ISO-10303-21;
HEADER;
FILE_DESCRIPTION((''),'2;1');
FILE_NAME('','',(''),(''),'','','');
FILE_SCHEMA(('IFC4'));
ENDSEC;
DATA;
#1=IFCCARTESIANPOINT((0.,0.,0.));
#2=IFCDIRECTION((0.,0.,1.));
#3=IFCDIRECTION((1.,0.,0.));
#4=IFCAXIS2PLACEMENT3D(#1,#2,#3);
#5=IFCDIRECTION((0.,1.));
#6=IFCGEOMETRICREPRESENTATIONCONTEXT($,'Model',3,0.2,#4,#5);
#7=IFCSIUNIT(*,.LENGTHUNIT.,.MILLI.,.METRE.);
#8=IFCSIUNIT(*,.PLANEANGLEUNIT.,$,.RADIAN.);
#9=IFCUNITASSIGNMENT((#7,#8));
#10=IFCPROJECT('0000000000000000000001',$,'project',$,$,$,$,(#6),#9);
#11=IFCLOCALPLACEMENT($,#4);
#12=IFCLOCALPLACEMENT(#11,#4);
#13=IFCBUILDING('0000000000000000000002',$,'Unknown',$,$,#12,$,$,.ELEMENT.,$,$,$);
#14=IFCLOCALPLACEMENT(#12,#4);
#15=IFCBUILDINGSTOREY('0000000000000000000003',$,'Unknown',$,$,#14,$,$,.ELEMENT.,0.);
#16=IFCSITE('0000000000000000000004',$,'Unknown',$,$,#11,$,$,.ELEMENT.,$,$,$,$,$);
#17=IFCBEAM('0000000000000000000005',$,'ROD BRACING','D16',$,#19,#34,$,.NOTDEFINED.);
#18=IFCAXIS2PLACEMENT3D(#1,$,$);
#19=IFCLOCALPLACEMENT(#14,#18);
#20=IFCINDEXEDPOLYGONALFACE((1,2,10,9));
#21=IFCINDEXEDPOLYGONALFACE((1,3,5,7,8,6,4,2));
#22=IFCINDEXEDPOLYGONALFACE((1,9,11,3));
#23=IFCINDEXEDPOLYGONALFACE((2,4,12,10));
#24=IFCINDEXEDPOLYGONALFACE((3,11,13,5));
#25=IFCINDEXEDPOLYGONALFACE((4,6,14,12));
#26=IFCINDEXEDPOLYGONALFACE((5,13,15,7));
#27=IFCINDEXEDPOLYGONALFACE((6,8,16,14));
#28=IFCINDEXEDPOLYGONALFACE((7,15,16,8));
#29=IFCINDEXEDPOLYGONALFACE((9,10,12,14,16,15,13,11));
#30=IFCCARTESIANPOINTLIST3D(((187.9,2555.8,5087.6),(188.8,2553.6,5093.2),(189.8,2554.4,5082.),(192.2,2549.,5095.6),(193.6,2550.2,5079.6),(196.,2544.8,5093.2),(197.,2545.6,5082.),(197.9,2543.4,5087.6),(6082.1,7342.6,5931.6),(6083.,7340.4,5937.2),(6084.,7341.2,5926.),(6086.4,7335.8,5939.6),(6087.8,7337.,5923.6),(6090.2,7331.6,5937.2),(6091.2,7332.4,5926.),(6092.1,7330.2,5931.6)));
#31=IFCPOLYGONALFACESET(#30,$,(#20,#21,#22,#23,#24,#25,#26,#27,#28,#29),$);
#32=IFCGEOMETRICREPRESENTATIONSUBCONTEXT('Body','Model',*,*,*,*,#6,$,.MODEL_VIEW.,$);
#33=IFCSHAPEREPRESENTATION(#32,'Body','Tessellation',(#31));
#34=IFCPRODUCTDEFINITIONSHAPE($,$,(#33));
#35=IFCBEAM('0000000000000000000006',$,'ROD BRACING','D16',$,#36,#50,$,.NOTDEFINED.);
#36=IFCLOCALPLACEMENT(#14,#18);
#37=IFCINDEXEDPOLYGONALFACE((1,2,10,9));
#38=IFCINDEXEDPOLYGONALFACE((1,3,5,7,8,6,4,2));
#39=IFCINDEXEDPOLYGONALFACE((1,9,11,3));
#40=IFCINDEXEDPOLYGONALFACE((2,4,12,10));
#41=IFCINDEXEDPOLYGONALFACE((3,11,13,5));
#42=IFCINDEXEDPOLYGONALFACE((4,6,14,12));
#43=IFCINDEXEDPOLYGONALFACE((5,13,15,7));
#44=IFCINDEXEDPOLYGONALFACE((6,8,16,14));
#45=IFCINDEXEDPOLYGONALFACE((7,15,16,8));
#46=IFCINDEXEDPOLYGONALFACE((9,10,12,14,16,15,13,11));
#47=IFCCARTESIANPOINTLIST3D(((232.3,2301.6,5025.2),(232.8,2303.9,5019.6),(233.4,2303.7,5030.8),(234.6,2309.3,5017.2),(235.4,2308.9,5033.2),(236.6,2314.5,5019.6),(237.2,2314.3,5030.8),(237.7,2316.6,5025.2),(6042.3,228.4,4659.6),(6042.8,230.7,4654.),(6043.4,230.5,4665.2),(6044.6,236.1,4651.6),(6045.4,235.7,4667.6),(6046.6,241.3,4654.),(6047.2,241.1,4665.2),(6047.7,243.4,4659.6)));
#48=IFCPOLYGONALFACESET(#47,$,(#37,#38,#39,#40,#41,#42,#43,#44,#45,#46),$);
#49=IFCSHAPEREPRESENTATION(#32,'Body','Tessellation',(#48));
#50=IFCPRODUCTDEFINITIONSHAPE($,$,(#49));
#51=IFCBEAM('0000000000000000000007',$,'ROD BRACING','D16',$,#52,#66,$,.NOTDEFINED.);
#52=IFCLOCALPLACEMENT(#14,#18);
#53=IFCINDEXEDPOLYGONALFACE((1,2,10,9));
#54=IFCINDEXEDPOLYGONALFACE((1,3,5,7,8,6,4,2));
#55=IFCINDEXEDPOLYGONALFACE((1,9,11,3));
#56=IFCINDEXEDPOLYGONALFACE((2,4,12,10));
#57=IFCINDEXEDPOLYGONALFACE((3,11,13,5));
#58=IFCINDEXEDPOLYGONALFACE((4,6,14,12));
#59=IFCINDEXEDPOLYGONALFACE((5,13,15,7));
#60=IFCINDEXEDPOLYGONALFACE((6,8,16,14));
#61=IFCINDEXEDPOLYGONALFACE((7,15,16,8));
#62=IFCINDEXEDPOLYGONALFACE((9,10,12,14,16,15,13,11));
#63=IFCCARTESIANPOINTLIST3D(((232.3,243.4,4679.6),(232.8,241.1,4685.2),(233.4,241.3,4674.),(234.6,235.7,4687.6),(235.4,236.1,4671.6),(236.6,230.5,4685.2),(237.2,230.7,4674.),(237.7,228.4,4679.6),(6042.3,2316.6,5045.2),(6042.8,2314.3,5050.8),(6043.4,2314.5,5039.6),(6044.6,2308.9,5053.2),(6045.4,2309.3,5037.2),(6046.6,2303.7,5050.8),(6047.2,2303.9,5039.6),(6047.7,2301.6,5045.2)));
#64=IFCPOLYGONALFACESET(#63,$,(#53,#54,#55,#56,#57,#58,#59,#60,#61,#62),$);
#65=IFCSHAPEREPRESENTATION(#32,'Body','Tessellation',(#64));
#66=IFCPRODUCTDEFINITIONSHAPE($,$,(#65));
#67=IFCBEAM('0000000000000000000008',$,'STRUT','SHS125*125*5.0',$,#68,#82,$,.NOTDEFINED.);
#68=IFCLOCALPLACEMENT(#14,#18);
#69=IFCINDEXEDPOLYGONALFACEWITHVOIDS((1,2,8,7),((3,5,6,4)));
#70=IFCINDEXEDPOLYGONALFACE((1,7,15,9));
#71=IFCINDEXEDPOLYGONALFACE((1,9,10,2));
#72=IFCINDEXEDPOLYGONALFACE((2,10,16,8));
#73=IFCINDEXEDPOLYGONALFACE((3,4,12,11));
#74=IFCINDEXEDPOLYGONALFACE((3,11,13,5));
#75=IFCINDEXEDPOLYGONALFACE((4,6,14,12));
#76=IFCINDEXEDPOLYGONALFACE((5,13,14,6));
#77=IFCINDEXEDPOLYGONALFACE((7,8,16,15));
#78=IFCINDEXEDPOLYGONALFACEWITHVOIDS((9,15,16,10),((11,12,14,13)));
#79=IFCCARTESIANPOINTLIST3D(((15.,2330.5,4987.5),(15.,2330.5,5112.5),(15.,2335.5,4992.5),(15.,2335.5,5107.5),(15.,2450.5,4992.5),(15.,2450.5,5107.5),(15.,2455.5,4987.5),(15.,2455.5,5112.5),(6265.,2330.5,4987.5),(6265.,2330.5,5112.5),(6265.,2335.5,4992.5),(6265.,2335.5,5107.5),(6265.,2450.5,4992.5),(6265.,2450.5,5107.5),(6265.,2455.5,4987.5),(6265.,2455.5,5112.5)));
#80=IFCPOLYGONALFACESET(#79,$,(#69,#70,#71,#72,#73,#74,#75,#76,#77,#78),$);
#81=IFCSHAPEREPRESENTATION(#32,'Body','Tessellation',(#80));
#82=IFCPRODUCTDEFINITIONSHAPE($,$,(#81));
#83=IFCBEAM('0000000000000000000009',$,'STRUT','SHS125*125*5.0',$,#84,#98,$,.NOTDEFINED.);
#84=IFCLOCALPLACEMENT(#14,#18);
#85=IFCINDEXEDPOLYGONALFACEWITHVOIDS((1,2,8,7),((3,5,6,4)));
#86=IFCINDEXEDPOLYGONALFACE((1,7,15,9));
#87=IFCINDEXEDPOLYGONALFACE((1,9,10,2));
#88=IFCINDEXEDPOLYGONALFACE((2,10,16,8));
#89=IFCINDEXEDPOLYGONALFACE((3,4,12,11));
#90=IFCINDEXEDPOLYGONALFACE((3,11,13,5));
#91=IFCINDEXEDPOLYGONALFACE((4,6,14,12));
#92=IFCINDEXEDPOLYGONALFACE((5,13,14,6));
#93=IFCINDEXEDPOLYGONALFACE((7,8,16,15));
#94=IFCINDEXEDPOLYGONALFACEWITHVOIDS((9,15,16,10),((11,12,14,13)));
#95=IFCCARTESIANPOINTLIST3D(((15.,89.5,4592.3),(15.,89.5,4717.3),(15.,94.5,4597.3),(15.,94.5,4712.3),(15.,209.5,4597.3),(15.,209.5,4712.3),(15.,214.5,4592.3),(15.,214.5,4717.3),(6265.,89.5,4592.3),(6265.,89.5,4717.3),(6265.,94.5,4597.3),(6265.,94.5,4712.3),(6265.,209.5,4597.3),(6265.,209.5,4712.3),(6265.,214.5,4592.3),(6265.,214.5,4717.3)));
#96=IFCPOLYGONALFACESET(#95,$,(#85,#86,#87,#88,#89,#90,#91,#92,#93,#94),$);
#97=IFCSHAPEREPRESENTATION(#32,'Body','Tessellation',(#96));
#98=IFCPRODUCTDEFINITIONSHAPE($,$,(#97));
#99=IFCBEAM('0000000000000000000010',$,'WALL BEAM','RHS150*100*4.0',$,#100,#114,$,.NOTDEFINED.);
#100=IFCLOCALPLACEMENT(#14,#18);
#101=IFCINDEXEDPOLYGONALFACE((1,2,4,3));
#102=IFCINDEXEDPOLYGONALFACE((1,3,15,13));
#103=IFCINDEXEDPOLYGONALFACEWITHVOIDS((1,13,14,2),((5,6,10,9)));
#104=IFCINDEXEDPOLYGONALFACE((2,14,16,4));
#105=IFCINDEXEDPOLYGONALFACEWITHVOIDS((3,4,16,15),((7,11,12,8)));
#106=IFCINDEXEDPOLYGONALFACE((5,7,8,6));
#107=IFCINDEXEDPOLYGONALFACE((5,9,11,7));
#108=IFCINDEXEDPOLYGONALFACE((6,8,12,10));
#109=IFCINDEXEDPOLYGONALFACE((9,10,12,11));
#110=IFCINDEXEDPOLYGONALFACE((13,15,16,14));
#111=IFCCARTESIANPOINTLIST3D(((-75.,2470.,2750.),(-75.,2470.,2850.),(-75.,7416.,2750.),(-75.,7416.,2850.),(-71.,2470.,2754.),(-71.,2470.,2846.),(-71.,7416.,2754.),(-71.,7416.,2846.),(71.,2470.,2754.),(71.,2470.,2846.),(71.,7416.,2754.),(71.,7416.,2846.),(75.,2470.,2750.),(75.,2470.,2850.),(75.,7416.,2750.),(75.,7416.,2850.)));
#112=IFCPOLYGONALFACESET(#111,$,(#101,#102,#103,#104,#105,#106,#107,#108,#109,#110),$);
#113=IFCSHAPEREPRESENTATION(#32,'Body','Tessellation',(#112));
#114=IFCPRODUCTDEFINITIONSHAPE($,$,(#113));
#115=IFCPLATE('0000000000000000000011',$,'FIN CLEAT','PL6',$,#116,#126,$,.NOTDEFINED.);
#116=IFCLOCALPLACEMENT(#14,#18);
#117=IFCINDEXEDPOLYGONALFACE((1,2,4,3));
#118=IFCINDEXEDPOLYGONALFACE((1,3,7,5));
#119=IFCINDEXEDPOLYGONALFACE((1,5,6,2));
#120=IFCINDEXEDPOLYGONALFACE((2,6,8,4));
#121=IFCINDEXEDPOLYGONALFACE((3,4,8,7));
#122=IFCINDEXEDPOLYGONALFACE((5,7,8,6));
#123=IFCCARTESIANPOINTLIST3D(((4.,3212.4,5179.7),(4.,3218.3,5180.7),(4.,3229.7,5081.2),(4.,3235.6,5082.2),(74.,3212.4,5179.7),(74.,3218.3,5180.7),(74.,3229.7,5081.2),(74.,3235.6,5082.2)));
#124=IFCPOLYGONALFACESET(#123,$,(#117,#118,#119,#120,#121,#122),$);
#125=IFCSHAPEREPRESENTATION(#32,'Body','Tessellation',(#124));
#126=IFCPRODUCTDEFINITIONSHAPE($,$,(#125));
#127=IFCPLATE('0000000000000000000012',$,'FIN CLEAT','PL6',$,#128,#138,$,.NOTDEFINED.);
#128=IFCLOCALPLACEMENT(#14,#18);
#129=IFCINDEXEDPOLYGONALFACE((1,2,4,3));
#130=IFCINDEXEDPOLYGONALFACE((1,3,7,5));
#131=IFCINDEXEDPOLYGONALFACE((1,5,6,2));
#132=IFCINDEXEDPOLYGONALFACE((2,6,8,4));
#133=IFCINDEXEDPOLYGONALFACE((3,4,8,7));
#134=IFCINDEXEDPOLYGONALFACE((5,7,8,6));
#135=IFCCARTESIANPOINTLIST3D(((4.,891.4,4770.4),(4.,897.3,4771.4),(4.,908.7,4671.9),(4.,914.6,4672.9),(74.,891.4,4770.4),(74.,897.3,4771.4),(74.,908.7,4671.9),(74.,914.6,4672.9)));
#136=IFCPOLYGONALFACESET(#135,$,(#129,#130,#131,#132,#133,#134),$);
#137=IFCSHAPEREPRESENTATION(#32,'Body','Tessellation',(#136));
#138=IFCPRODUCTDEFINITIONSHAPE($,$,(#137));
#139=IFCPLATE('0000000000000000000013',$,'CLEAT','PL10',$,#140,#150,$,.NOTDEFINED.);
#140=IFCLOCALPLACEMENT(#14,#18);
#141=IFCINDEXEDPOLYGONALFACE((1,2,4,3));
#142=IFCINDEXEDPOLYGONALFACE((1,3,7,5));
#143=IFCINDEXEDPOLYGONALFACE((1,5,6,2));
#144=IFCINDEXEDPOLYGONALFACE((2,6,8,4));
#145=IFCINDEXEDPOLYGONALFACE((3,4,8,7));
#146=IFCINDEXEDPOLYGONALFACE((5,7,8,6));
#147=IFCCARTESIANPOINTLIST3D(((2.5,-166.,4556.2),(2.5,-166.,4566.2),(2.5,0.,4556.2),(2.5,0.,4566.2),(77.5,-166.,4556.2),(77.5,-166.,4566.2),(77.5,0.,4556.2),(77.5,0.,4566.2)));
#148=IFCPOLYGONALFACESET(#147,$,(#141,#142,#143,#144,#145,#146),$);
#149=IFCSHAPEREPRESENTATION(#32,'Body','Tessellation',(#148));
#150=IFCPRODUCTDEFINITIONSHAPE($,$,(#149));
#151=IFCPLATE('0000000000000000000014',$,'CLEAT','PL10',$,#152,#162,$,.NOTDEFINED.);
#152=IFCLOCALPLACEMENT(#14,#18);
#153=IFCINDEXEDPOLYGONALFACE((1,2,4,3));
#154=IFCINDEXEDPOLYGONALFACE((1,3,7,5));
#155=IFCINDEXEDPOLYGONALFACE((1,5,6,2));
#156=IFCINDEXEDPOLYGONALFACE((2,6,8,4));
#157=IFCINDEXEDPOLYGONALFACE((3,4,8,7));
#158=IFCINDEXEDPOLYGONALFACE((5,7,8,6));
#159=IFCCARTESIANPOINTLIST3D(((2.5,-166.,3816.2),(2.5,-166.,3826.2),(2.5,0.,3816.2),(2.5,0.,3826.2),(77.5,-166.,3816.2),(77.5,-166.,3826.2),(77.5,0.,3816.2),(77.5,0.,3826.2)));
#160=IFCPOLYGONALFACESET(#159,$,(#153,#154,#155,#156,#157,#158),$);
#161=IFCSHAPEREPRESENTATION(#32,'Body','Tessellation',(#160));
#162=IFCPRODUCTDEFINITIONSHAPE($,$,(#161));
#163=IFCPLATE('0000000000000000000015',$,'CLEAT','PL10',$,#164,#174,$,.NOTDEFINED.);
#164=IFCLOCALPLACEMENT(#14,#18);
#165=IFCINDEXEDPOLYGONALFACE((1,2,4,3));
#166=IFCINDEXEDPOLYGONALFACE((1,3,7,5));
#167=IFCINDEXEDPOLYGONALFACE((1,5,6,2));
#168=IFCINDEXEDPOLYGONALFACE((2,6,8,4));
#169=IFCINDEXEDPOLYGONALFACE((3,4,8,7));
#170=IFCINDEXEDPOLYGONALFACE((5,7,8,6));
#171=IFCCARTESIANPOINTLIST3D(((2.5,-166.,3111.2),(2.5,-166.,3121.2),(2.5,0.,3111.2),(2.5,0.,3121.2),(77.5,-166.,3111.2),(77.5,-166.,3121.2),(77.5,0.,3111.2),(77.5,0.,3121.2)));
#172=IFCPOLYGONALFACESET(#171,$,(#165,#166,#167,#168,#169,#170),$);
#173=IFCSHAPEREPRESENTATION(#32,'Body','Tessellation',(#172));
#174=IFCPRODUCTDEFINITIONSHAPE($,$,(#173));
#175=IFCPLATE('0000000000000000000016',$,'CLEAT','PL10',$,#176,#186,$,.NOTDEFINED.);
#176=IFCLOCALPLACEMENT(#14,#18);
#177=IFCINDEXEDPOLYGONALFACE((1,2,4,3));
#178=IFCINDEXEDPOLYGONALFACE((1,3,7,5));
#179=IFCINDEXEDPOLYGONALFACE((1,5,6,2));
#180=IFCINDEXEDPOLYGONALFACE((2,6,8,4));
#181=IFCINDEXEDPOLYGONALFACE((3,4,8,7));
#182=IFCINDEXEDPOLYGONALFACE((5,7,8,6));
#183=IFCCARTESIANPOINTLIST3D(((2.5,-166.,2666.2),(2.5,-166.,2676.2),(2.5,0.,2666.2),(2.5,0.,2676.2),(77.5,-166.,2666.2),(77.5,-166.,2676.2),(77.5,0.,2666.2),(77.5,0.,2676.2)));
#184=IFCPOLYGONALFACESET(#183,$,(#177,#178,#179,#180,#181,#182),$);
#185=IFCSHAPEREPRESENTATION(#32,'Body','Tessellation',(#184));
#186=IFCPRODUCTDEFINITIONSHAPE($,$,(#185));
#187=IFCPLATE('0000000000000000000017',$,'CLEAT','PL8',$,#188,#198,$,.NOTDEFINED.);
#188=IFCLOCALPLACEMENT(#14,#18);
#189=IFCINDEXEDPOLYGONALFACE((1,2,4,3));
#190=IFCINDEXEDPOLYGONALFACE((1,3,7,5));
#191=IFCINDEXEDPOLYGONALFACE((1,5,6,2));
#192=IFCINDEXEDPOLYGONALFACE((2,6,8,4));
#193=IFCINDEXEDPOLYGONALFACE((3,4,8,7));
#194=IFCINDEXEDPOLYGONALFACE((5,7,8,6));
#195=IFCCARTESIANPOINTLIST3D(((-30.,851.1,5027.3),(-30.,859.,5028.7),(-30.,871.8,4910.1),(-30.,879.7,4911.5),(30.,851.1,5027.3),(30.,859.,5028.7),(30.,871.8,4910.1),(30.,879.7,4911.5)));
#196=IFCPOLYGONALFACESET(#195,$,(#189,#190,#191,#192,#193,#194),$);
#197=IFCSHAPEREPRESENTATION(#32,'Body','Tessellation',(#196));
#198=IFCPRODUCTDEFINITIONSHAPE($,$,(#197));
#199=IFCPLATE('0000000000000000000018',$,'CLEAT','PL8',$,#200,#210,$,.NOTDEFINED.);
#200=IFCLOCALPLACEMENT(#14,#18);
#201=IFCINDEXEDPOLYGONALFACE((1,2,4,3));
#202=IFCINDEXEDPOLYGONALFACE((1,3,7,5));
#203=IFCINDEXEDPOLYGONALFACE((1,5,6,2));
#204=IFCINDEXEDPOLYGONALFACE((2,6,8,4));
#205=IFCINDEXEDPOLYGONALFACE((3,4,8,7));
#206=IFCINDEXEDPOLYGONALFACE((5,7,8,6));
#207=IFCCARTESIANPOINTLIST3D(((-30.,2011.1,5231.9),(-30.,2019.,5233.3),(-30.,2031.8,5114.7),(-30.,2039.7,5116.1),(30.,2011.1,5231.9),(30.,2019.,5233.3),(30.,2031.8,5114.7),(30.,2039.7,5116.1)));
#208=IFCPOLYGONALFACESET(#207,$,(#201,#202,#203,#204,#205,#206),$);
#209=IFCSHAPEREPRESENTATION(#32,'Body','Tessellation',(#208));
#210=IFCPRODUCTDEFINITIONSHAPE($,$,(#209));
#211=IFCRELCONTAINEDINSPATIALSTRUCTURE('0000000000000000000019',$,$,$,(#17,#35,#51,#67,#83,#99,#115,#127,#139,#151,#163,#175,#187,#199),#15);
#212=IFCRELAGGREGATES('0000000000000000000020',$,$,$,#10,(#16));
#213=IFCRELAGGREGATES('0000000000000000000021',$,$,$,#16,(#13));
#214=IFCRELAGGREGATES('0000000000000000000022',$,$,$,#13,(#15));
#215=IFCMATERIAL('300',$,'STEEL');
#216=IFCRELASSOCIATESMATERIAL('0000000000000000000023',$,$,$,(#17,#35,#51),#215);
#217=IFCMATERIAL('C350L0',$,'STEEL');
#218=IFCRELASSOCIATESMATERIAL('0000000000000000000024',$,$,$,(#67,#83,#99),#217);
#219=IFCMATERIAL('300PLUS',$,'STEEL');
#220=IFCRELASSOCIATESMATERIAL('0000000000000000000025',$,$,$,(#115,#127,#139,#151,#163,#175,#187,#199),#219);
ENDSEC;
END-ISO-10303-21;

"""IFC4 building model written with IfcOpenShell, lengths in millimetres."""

from ifc_helpers import new_model, si_unit, direction, frame, origin_with_axes, place, context, subcontext, project, spatial, line, indexed_curve, outline, extrude, material, element, save


model = new_model("IFC4")

# Units and contexts
model_context = context("Model", 3, precision=0.2, world=origin_with_axes(), true_north=direction((0.0, 1.0)))
body_context = subcontext(model_context, "Body", "Model", "MODEL_VIEW")
ifc_project = project(units=[si_unit("LENGTHUNIT", "METRE", prefix="MILLI"), si_unit("PLANEANGLEUNIT", "RADIAN")], contexts=[model_context])

# Site, building, storey
site_placement = place(None, origin_with_axes())
site = spatial("IfcSite", under=ifc_project, at=site_placement, Name="Unknown", CompositionType="ELEMENT")
building_placement = place(site_placement, origin_with_axes())
building = spatial("IfcBuilding", under=site, at=building_placement, Name="Unknown", CompositionType="ELEMENT")
storey_placement = place(building_placement, origin_with_axes())
storey = spatial("IfcBuildingStorey", under=building, at=storey_placement, Name="Unknown", CompositionType="ELEMENT", Elevation=0.0)

# Shared definitions
ifc_material_1 = material(Name="300PLUS", Category="STEEL")

# Beams
ifc_material_2 = material(Name="300", Category="STEEL")
beam_1_placement = place(storey_placement, frame((192.9, 2549.6, 5087.6), z_axis=(-0.085756, -0.069644, 0.993879), x_axis=(0.771507, 0.626556, 0.110473)))
element("IfcBeam", 1, at=beam_1_placement, inside=storey, material=ifc_material_2, Name="ROD BRACING", Description="D16", PredefinedType="NOTDEFINED", context=body_context, shape_type="SolidModel", body=[
    extrude(outline(indexed_curve([(8.0, 0.0), (5.7, 5.7), (0.0, 8.0), (-5.7, 5.7), (-8.0, 0.0), (-5.7, -5.7), (0.0, -8.0), (5.7, -5.7)], segments=[line(1, 2, 3, 4, 5, 6, 7, 8, 1)])), frame((0.0, 0.0, 0.0), z_axis=(-1.0, 0.0, 0.0), x_axis=(0.0, 0.0, 1.0)), (0.0, 0.0, -1.0), 7639.9),
])
for number, where, z_axis, x_axis, name in (
    (2, (235.0, 2309.1, 5025.2), (0.055721, -0.019883, 0.998248), (0.940185, -0.335489, -0.059162), "ROD BRACING"),
    (3, (235.0, 235.9, 4679.6), (-0.055721, -0.019883, 0.998248), (0.940185, 0.335489, 0.059162), "ROD BRACING"),
):
    element("IfcBeam", number, at=place(storey_placement, frame(where, z_axis=z_axis, x_axis=x_axis)), inside=storey, material=ifc_material_2, Name=name, Description="D16", PredefinedType="NOTDEFINED", context=body_context, shape_type="SolidModel", body=[
        extrude(outline(indexed_curve([(8.0, 0.0), (5.7, 5.7), (0.0, 8.0), (-5.7, 5.7), (-8.0, 0.0), (-5.7, -5.7), (0.0, -8.0), (5.7, -5.7)], segments=[line(1, 2, 3, 4, 5, 6, 7, 8, 1)])), frame((0.0, 0.0, 0.0), z_axis=(-1.0, 0.0, 0.0), x_axis=(0.0, 0.0, 1.0)), (0.0, 0.0, -1.0), 6179.6),
    ])
ifc_material_3 = material(Name="C350L0", Category="STEEL")
for number, where, z_axis, x_axis, name in (
    (4, (15.0, 2393.0, 5050.0), (0.0, 0.0, 1.0), (1.0, 0.0, 0.0), "STRUT"),
    (5, (15.0, 152.0, 4654.8), (0.0, 0.0, 1.0), (1.0, 0.0, 0.0), "STRUT"),
):
    element("IfcBeam", number, at=place(storey_placement, frame(where, z_axis=z_axis, x_axis=x_axis)), inside=storey, material=ifc_material_3, Name=name, Description="SHS125*125*5.0", PredefinedType="NOTDEFINED", context=body_context, shape_type="SolidModel", body=[
        extrude(outline(indexed_curve([(-62.5, -62.5), (62.5, -62.5), (62.5, 62.5), (-62.5, 62.5)], segments=[line(1, 2, 3, 4, 1)]), holes=[indexed_curve([(-57.5, -57.5), (-57.5, 57.5), (57.5, 57.5), (57.5, -57.5)], segments=[line(1, 2, 3, 4, 1)])]), frame((0.0, 0.0, 0.0), z_axis=(-1.0, 0.0, 0.0), x_axis=(0.0, 0.0, 1.0)), (0.0, 0.0, -1.0), 6250.0),
    ])
beam_2_placement = place(storey_placement, frame((0.0, 2470.0, 2800.0), z_axis=(0.0, 0.0, 1.0), x_axis=(0.0, 1.0, 0.0)))
element("IfcBeam", 6, at=beam_2_placement, inside=storey, material=ifc_material_3, Name="WALL BEAM", Description="RHS150*100*4.0", PredefinedType="NOTDEFINED", context=body_context, shape_type="SolidModel", body=[
    extrude(outline(indexed_curve([(-50.0, -75.0), (50.0, -75.0), (50.0, 75.0), (-50.0, 75.0)], segments=[line(1, 2, 3, 4, 1)]), holes=[indexed_curve([(-46.0, -71.0), (-46.0, 71.0), (46.0, 71.0), (46.0, -71.0)], segments=[line(1, 2, 3, 4, 1)])]), frame((0.0, 0.0, 0.0), z_axis=(-1.0, 0.0, 0.0), x_axis=(0.0, 0.0, 1.0)), (0.0, 0.0, -1.0), 4946.0),
])

# Plates
for number, where, z_axis, x_axis, name in (
    (7, (4.0, 3215.4, 5180.2), (0.0, 0.984924, 0.172987), (1.0, 0.0, 0.0), "FIN CLEAT"),
    (8, (4.0, 894.4, 4770.9), (0.0, 0.984924, 0.172987), (1.0, 0.0, 0.0), "FIN CLEAT"),
):
    element("IfcPlate", number, at=place(storey_placement, frame(where, z_axis=z_axis, x_axis=x_axis)), inside=storey, material=ifc_material_1, Name=name, Description="PL6", PredefinedType="NOTDEFINED", context=body_context, shape_type="SolidModel", body=[
        extrude(outline(indexed_curve([(0.0, 0.0), (70.0, 0.0), (70.0, 100.0), (0.0, 100.0)], segments=[line(1, 2, 3, 4, 1)])), frame((0.0, 0.0, 3.0), z_axis=(0.0, 0.0, 1.0), x_axis=(1.0, 0.0, 0.0)), (0.0, 0.0, -1.0), 6.0),
    ])
for number, where, z_axis, x_axis, name in (
    (9, (77.5, 0.0, 4561.2), (0.0, 0.0, 1.0), (-1.0, 0.0, 0.0), "CLEAT"),
    (10, (77.5, 0.0, 3821.2), (0.0, 0.0, 1.0), (-1.0, 0.0, 0.0), "CLEAT"),
    (11, (77.5, 0.0, 3116.2), (0.0, 0.0, 1.0), (-1.0, 0.0, 0.0), "CLEAT"),
    (12, (77.5, 0.0, 2671.2), (0.0, 0.0, 1.0), (-1.0, 0.0, 0.0), "CLEAT"),
):
    element("IfcPlate", number, at=place(storey_placement, frame(where, z_axis=z_axis, x_axis=x_axis)), inside=storey, material=ifc_material_1, Name=name, Description="PL10", PredefinedType="NOTDEFINED", context=body_context, shape_type="SolidModel", body=[
        extrude(outline(indexed_curve([(0.0, 0.0), (75.0, 0.0), (75.0, 166.0), (0.0, 166.0)], segments=[line(1, 2, 3, 4, 1)])), frame((0.0, 0.0, 5.0), z_axis=(0.0, 0.0, 1.0), x_axis=(1.0, 0.0, 0.0)), (0.0, 0.0, -1.0), 10.0),
    ])
for number, where, z_axis, x_axis, name in (
    (13, (30.0, 875.7, 4910.8), (0.0, 0.984758, 0.173929), (-1.0, 0.0, 0.0), "CLEAT"),
    (14, (30.0, 2035.7, 5115.4), (0.0, 0.984758, 0.173929), (-1.0, 0.0, 0.0), "CLEAT"),
):
    element("IfcPlate", number, at=place(storey_placement, frame(where, z_axis=z_axis, x_axis=x_axis)), inside=storey, material=ifc_material_1, Name=name, Description="PL8", PredefinedType="NOTDEFINED", context=body_context, shape_type="SolidModel", body=[
        extrude(outline(indexed_curve([(0.0, 0.0), (60.0, 0.0), (60.0, 119.0), (0.0, 119.0)], segments=[line(1, 2, 3, 4, 1)])), frame((0.0, 0.0, 4.0), z_axis=(0.0, 0.0, 1.0), x_axis=(1.0, 0.0, 0.0)), (0.0, 0.0, -1.0), 8.0),
    ])

save(model, "model.ifc")
